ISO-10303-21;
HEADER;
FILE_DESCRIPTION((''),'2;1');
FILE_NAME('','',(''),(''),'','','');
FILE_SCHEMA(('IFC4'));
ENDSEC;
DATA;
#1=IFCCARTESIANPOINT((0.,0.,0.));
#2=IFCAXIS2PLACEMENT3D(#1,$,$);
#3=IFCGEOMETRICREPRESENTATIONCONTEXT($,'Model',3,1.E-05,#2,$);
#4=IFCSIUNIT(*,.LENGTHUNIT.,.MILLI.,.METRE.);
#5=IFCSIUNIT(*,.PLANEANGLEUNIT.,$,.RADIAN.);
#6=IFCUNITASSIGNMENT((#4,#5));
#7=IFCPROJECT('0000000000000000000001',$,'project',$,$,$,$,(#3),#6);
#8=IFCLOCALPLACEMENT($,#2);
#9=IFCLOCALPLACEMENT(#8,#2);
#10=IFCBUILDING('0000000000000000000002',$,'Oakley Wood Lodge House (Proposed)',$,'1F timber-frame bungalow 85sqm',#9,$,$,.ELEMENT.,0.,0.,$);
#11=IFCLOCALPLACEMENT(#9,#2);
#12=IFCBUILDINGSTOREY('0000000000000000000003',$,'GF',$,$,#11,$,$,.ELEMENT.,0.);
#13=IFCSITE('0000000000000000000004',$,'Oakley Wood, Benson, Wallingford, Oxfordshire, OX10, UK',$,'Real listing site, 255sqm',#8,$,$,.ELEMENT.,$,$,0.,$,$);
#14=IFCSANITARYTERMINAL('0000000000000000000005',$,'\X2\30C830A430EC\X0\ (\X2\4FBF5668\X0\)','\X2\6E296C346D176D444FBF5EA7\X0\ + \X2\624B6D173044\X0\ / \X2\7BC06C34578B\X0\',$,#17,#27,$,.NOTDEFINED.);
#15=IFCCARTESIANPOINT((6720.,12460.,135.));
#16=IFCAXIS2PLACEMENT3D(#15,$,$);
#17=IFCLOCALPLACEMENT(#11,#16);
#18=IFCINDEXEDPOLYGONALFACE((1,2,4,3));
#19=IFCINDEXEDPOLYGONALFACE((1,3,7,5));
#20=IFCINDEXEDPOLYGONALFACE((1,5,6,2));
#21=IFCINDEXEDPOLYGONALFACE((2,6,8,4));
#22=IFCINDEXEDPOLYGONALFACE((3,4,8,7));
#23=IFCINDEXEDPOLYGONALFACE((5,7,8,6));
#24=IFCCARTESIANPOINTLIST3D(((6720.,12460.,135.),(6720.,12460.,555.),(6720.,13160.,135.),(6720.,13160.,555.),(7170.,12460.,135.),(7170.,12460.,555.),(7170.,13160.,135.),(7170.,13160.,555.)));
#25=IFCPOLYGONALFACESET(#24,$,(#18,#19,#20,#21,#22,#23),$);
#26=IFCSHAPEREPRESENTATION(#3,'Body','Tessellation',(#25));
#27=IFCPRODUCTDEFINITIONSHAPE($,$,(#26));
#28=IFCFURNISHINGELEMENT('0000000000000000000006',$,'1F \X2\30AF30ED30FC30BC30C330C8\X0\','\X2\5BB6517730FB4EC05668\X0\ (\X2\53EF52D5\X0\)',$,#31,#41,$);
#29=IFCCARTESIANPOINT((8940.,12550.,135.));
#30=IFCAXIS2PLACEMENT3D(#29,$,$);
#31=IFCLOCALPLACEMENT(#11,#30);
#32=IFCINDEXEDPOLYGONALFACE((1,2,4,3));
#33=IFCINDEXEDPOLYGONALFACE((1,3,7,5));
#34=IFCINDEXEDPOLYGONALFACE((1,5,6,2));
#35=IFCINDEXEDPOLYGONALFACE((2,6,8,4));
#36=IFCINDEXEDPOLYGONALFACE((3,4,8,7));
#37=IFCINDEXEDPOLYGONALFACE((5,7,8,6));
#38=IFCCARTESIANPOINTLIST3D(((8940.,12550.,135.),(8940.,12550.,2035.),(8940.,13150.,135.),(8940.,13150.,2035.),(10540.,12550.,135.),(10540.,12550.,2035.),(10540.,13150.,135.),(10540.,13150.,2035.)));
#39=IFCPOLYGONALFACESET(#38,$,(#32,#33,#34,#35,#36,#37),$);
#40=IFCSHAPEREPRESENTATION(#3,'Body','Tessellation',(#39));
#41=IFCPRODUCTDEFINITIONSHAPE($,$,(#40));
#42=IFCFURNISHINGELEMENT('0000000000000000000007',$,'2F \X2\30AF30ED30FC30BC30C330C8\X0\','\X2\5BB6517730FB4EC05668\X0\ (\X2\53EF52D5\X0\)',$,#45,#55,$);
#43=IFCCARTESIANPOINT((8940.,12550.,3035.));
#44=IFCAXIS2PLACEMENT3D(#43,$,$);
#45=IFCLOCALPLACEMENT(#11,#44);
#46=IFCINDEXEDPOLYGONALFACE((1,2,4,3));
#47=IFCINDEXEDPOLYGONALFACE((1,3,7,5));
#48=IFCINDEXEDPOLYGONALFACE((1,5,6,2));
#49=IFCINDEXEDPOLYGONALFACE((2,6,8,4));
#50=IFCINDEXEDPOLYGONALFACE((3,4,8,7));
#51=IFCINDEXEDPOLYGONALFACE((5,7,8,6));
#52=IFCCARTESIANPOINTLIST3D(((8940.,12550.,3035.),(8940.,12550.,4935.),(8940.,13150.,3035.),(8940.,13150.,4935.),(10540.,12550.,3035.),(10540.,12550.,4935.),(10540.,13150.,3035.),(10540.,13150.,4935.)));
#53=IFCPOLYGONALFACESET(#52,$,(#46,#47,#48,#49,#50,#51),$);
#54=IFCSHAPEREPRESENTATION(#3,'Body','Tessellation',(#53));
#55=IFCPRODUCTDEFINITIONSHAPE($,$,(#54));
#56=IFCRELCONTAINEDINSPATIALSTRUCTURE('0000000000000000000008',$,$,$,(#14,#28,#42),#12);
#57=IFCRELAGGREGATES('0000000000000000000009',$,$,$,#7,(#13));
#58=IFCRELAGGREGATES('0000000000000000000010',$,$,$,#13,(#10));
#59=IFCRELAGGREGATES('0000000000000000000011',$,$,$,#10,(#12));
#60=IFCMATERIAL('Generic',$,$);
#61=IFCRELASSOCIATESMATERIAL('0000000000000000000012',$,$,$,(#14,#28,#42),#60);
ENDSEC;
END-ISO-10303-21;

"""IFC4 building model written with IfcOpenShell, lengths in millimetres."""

from ifc_helpers import new_model, si_unit, frame, frame_2d, origin, place, context, project, spatial, rectangle, extrude, material, element, save


model = new_model("IFC4")

# Units and contexts
model_context = context("Model", 3, precision=1e-05, world=origin())
ifc_project = project(units=[si_unit("LENGTHUNIT", "METRE", prefix="MILLI"), si_unit("PLANEANGLEUNIT", "RADIAN")], contexts=[model_context])

# Site, building, storey
site_placement = place(None, origin())
site = spatial("IfcSite", under=ifc_project, at=site_placement, Name="Oakley Wood, Benson, Wallingford, Oxfordshire, OX10, UK", ObjectType="Real listing site, 255sqm", CompositionType="ELEMENT", RefElevation=0.0)
building_placement = place(site_placement, origin())
building = spatial("IfcBuilding", under=site, at=building_placement, Name="Oakley Wood Lodge House (Proposed)", ObjectType="1F timber-frame bungalow 85sqm", CompositionType="ELEMENT", ElevationOfRefHeight=0.0, ElevationOfTerrain=0.0)
storey_placement = place(building_placement, origin())
storey = spatial("IfcBuildingStorey", under=building, at=storey_placement, Name="GF", CompositionType="ELEMENT", Elevation=0.0)

# Sanitary terminal
ifc_material_1 = material(Name="Generic")
sanitary_terminal_1_placement = place(storey_placement, frame((6720.0, 12460.0, 135.0)))
element("IfcSanitaryTerminal", 1, at=sanitary_terminal_1_placement, inside=storey, material=ifc_material_1, Name="トイレ (便器)", Description="温水洗浄便座 + 手洗い / 節水型", PredefinedType="NOTDEFINED", context=model_context, shape_type="SweptSolid", body=[
    extrude(rectangle(XDim=450.0, YDim=700.0, at=frame_2d((225.0, 350.0))), frame((6720.0, 12460.0, 135.0)), (0.0, 0.0, 1.0), 420.0),
])

# Furnishing elements
furnishing_1_placement = place(storey_placement, frame((8940.0, 12550.0, 135.0)))
element("IfcFurnishingElement", 2, at=furnishing_1_placement, inside=storey, material=ifc_material_1, Name="1F クローゼット", Description="家具・什器 (可動)", context=model_context, shape_type="SweptSolid", body=[
    extrude(rectangle(XDim=1600.0, YDim=600.0, at=frame_2d((800.0, 300.0))), frame((8940.0, 12550.0, 135.0)), (0.0, 0.0, 1.0), 1900.0),
])
furnishing_2_placement = place(storey_placement, frame((8940.0, 12550.0, 3035.0)))
element("IfcFurnishingElement", 3, at=furnishing_2_placement, inside=storey, material=ifc_material_1, Name="2F クローゼット", Description="家具・什器 (可動)", context=model_context, shape_type="SweptSolid", body=[
    extrude(rectangle(XDim=1600.0, YDim=600.0, at=frame_2d((800.0, 300.0))), frame((8940.0, 12550.0, 3035.0)), (0.0, 0.0, 1.0), 1900.0),
])

save(model, "model.ifc")
